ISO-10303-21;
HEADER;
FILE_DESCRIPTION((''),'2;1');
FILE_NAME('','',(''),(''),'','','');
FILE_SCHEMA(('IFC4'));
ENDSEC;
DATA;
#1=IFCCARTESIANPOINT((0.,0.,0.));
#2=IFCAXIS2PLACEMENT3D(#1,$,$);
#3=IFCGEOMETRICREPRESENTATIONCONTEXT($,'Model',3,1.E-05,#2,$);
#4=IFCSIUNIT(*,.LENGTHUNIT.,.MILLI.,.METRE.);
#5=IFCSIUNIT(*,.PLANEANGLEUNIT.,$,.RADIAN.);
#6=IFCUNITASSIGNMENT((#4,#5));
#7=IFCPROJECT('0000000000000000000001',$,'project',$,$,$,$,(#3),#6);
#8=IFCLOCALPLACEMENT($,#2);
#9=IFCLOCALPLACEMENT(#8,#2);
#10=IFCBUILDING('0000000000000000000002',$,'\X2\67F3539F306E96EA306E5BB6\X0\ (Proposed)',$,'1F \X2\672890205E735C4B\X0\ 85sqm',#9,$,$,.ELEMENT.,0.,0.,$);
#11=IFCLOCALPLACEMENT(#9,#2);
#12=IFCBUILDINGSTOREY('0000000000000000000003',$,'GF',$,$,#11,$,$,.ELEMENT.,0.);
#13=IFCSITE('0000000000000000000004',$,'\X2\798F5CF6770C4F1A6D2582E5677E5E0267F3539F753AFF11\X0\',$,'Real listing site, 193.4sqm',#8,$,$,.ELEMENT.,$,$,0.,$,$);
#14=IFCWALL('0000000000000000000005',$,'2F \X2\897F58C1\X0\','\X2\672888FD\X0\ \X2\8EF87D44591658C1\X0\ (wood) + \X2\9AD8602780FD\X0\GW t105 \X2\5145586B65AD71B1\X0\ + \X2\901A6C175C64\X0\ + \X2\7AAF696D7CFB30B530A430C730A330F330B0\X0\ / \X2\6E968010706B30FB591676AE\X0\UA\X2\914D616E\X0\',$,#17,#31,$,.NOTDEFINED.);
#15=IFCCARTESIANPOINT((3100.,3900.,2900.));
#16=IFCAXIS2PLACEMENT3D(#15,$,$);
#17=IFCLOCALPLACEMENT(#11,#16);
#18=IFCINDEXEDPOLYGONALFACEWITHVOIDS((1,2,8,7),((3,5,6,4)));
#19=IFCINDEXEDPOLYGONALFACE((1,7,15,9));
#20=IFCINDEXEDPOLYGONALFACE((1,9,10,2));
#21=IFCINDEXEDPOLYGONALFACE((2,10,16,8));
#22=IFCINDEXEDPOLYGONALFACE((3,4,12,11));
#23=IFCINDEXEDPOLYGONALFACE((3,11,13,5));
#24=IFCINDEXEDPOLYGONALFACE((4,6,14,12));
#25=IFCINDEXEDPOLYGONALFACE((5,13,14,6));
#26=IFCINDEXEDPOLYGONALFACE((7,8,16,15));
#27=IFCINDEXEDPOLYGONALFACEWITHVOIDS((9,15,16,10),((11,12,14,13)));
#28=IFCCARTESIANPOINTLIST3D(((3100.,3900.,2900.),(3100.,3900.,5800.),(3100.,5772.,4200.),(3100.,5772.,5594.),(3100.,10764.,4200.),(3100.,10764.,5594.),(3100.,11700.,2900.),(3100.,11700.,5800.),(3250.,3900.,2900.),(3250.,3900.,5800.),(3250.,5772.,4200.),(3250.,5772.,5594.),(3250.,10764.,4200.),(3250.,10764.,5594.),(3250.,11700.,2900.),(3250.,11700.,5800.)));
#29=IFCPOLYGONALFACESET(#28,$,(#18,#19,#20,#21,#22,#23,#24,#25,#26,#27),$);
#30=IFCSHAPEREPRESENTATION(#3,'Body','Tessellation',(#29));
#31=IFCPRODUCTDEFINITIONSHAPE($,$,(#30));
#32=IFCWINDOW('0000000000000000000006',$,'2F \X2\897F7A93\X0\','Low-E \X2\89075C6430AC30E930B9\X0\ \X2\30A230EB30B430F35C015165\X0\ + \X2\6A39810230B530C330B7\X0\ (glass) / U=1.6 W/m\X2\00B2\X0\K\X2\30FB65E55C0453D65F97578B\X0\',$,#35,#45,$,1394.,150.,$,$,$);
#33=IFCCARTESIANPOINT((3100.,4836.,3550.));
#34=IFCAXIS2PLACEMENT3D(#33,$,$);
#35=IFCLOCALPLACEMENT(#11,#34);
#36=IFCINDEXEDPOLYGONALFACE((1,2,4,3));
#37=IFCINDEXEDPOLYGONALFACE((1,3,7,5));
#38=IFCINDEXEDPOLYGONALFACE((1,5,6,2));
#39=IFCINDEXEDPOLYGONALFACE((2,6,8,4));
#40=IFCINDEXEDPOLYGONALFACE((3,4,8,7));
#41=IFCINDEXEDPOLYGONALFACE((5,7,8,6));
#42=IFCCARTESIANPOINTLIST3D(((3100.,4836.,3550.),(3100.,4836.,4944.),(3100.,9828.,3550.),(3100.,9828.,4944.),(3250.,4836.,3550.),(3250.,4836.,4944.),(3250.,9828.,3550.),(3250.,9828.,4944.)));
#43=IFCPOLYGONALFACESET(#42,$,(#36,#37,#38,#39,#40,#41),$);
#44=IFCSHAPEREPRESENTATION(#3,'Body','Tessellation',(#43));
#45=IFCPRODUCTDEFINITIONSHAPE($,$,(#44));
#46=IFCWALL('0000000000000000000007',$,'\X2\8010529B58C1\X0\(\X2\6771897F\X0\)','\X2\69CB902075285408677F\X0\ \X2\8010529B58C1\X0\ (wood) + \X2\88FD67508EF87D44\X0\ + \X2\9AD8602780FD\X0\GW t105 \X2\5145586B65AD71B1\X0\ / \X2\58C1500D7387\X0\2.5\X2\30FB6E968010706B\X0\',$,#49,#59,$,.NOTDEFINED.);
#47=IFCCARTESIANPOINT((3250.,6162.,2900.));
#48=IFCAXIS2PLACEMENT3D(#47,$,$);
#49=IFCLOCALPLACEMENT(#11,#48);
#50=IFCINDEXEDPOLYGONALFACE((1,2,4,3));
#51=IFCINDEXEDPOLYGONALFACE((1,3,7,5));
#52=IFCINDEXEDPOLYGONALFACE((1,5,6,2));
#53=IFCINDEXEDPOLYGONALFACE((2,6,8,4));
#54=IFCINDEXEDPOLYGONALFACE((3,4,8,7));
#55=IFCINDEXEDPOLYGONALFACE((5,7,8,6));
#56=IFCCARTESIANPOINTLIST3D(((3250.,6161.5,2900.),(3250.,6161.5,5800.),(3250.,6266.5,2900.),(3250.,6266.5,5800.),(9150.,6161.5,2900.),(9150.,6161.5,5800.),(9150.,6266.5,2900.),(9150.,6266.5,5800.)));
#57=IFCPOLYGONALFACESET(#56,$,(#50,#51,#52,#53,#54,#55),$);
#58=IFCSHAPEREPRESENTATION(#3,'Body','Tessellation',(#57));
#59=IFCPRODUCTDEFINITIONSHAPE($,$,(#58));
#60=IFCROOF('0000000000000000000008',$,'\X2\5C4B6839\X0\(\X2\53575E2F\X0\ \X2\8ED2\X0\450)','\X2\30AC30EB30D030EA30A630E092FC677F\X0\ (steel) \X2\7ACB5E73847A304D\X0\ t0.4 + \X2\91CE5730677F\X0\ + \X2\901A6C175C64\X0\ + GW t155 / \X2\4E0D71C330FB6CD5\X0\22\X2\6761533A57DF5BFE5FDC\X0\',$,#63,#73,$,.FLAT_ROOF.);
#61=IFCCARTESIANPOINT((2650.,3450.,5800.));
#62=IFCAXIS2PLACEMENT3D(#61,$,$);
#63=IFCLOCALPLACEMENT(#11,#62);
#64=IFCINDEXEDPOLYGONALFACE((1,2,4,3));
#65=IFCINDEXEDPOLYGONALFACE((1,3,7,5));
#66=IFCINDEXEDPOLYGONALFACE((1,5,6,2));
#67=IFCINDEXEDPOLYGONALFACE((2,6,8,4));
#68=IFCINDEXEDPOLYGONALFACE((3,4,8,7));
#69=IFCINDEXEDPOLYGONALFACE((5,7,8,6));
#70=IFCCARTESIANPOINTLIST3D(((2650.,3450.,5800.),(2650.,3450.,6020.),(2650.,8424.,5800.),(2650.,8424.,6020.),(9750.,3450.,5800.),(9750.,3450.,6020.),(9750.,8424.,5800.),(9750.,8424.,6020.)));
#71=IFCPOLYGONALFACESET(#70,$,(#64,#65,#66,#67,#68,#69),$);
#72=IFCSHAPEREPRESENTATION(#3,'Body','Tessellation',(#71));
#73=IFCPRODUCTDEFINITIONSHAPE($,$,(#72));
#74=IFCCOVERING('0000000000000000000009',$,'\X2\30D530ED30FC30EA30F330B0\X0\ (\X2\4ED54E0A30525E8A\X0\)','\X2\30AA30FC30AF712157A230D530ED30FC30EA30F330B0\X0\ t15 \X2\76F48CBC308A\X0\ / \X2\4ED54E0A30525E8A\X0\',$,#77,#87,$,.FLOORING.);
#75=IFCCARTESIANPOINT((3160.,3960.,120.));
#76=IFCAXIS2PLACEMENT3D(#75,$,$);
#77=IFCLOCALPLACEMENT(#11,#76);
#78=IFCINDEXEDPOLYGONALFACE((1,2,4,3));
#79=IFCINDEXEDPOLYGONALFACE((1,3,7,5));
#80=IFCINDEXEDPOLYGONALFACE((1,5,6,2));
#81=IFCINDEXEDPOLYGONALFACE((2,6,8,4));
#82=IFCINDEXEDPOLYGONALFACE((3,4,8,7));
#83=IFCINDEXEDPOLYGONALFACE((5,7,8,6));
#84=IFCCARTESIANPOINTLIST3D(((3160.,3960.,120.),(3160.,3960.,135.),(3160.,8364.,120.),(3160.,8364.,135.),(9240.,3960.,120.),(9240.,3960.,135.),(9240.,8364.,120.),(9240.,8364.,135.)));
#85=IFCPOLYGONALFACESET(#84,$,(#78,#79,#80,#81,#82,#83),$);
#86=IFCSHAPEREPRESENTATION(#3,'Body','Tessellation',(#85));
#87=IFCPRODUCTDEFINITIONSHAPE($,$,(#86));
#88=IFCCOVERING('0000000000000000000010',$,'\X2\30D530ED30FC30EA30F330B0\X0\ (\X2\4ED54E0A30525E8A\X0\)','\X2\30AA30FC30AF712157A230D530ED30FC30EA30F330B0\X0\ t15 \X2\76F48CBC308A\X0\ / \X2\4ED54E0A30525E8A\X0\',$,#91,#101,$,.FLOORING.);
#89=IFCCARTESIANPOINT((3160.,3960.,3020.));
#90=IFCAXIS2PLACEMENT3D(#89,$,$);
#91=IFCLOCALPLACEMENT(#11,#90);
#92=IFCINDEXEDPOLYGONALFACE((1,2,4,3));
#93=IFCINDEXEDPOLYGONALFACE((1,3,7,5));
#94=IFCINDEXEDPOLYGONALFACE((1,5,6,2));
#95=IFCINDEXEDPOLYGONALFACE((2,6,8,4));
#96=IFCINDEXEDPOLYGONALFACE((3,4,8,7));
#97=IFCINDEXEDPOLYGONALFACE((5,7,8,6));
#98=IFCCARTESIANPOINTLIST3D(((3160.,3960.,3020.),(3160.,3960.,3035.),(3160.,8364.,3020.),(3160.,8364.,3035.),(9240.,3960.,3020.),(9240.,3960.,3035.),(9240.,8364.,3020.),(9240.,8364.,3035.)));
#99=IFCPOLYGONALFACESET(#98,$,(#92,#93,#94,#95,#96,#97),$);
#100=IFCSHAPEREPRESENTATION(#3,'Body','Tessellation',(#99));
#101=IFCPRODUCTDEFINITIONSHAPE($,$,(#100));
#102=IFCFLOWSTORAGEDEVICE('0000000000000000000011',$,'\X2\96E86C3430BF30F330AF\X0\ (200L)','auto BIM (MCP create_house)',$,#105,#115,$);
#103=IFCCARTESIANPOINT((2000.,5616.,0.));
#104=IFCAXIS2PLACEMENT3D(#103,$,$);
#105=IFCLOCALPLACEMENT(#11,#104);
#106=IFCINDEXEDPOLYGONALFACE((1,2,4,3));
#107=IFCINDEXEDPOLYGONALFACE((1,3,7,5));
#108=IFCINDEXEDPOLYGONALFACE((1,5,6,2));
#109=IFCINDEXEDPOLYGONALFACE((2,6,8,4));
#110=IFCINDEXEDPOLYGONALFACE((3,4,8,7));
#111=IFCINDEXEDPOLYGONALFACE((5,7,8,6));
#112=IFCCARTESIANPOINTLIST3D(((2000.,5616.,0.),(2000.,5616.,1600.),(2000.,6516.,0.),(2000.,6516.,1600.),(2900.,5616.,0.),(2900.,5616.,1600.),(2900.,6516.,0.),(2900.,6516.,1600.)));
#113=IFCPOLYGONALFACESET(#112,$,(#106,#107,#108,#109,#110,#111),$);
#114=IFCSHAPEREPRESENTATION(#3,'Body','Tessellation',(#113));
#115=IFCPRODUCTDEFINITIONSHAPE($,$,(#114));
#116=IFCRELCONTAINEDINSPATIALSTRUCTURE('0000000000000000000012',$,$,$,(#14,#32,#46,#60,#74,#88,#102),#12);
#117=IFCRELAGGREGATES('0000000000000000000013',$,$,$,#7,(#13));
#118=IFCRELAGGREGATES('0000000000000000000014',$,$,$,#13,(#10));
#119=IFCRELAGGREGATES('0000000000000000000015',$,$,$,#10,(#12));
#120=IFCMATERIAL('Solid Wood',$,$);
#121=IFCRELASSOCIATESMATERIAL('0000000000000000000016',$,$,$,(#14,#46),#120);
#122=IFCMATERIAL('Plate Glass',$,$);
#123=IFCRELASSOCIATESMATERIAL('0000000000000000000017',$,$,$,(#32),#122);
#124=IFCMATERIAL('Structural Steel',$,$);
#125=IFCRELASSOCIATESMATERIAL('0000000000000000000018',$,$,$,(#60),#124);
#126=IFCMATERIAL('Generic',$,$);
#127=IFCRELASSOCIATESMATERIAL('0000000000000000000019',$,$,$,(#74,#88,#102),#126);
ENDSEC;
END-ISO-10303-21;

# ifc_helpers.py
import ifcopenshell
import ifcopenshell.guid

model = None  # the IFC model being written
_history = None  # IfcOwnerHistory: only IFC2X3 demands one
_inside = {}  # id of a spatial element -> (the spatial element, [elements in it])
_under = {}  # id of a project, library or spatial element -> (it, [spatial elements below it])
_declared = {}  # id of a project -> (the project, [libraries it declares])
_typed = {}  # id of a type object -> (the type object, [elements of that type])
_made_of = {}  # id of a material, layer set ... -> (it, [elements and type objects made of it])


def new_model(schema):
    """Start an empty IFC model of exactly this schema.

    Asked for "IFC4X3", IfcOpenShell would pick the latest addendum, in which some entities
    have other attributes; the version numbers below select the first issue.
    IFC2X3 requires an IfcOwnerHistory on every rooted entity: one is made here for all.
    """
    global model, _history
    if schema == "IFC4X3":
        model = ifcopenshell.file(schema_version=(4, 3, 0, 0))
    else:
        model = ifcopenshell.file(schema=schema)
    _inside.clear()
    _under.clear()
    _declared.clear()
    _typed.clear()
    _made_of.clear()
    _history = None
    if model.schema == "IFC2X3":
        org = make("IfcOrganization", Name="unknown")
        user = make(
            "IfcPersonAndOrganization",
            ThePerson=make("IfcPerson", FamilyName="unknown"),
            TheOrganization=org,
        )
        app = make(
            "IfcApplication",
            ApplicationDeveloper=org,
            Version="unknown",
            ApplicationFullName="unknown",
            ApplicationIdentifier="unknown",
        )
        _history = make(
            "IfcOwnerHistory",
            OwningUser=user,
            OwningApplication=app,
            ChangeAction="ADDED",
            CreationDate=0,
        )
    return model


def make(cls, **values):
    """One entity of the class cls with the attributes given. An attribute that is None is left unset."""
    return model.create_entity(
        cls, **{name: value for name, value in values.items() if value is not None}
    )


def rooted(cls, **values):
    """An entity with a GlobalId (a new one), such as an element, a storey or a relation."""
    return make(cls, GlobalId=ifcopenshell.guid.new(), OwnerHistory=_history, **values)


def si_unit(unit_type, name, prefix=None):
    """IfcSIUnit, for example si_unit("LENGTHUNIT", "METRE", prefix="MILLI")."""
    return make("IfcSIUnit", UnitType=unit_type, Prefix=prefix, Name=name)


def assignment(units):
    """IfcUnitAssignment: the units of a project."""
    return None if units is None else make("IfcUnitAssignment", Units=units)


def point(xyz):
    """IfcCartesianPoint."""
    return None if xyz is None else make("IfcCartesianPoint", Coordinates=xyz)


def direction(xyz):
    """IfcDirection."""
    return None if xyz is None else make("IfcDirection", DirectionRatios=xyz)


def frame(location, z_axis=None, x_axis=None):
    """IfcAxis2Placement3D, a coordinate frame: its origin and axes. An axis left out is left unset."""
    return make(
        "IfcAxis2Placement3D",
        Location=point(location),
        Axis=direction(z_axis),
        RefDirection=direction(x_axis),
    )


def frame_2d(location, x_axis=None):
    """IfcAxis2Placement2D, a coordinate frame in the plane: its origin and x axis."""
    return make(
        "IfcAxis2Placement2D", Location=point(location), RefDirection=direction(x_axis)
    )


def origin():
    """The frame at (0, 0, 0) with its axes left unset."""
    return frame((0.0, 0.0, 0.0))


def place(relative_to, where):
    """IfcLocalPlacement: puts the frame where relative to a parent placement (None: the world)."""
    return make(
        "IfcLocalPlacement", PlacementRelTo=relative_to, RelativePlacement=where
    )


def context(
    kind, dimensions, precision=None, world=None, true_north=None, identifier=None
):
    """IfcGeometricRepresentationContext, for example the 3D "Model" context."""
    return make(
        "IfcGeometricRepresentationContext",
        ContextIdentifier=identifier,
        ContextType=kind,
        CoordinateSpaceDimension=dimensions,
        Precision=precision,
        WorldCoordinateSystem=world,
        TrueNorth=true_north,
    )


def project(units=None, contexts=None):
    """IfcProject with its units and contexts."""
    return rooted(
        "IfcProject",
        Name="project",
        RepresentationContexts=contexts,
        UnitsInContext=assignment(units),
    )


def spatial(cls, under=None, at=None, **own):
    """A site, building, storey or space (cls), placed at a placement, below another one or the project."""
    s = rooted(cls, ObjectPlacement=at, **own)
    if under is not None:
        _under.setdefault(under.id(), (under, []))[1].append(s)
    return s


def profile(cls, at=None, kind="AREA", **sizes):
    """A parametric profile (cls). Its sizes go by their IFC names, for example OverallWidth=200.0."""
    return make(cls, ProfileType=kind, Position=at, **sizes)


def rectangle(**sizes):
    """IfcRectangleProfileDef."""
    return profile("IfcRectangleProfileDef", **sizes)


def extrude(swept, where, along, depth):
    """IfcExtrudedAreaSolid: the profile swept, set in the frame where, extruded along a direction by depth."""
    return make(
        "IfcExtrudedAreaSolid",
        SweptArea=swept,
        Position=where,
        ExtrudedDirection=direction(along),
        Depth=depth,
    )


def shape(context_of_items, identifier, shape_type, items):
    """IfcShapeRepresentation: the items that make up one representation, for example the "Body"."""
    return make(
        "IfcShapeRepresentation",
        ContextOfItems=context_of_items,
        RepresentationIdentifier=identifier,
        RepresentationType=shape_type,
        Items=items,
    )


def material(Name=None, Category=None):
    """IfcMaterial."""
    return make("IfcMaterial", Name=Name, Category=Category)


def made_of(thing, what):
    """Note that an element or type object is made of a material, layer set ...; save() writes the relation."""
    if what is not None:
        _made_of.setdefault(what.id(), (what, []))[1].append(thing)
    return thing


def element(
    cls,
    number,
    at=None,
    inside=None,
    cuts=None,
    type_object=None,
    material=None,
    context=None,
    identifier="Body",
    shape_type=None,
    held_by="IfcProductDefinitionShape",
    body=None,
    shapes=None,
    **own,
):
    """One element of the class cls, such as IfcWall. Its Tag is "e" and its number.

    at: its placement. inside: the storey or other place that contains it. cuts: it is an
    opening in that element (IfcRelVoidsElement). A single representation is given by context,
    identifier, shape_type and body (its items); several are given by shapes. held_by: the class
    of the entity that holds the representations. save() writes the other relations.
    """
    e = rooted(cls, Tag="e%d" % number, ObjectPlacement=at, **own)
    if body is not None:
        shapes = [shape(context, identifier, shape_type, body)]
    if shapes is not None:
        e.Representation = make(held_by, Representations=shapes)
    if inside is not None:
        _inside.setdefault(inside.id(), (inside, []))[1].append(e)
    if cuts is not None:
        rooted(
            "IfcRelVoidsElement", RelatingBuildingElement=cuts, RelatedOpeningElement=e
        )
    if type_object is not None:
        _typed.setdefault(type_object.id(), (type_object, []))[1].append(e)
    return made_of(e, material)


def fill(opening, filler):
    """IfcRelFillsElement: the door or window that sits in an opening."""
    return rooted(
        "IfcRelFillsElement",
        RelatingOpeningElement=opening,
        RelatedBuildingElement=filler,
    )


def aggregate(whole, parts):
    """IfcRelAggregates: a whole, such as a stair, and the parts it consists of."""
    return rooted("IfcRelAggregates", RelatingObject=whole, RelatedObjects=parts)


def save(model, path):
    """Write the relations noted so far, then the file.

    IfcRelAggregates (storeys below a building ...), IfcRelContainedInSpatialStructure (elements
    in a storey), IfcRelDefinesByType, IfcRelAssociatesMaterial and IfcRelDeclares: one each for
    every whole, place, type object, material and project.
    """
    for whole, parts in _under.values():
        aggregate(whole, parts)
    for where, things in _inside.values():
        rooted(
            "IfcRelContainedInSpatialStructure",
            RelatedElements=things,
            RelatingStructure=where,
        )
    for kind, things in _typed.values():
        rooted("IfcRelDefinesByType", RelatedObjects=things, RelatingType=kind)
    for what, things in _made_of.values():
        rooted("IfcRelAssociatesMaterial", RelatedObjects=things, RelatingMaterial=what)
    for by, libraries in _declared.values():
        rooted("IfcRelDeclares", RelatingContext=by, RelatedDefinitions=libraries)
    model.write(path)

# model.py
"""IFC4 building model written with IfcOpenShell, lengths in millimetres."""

from ifc_helpers import new_model, si_unit, frame, frame_2d, origin, place, context, project, spatial, rectangle, extrude, material, element, fill, save


model = new_model("IFC4")

# Units and contexts
model_context = context("Model", 3, precision=1e-05, world=origin())
ifc_project = project(units=[si_unit("LENGTHUNIT", "METRE", prefix="MILLI"), si_unit("PLANEANGLEUNIT", "RADIAN")], contexts=[model_context])

# Site, building, storey
site_placement = place(None, origin())
site = spatial("IfcSite", under=ifc_project, at=site_placement, Name="福島県会津若松市柳原町１", ObjectType="Real listing site, 193.4sqm", CompositionType="ELEMENT", RefElevation=0.0)
building_placement = place(site_placement, origin())
building = spatial("IfcBuilding", under=site, at=building_placement, Name="柳原の雪の家 (Proposed)", ObjectType="1F 木造平屋 85sqm", CompositionType="ELEMENT", ElevationOfRefHeight=0.0, ElevationOfTerrain=0.0)
storey_placement = place(building_placement, origin())
storey = spatial("IfcBuildingStorey", under=building, at=storey_placement, Name="GF", CompositionType="ELEMENT", Elevation=0.0)

# Shared definitions
ifc_material_1 = material(Name="Solid Wood")
ifc_material_2 = material(Name="Generic")

# Shared definitions
ifc_material_3 = material(Name="Plate Glass")

# Wall, opening, window
wall_1_placement = place(storey_placement, frame((3100.0, 3900.0, 2900.0)))
wall_1 = element("IfcWall", 1, at=wall_1_placement, inside=storey, material=ifc_material_1, Name="2F 西壁", Description="木製 軸組外壁 (wood) + 高性能GW t105 充填断熱 + 通気層 + 窯業系サイディング / 準耐火・外皮UA配慮", PredefinedType="NOTDEFINED", context=model_context, shape_type="SweptSolid", body=[
    extrude(rectangle(XDim=150.0, YDim=7800.0, at=frame_2d((75.0, 3900.0))), frame((3100.0, 3900.0, 2900.0)), (0.0, 0.0, 1.0), 2900.0),
])
opening_1_placement = place(storey_placement, frame((3100.0, 4836.0, 3550.0)))
opening_1 = element("IfcOpeningElement", 2, at=opening_1_placement, cuts=wall_1, PredefinedType="NOTDEFINED", context=model_context, shape_type="SweptSolid", body=[
    extrude(rectangle(XDim=150.0, YDim=4992.0, at=frame_2d((75.0, 2496.0))), frame((3100.0, 4836.0, 3550.0)), (0.0, 0.0, 1.0), 1394.0),
])
window_1_placement = place(storey_placement, frame((3100.0, 4836.0, 3550.0)))
window_1 = element("IfcWindow", 3, at=window_1_placement, inside=storey, material=ifc_material_3, Name="2F 西窓", Description="Low-E 複層ガラス アルゴン封入 + 樹脂サッシ (glass) / U=1.6 W/m²K・日射取得型", OverallHeight=1394.0, OverallWidth=150.0, context=model_context, shape_type="SweptSolid", body=[
    extrude(rectangle(XDim=150.0, YDim=4992.0, at=frame_2d((75.0, 2496.0))), frame((3100.0, 4836.0, 3550.0)), (0.0, 0.0, 1.0), 1394.0),
])
fill(opening_1, window_1)

# Wall
wall_2_placement = place(storey_placement, frame((3250.0, 6162.0, 2900.0)))
element("IfcWall", 4, at=wall_2_placement, inside=storey, material=ifc_material_1, Name="耐力壁(東西)", Description="構造用合板 耐力壁 (wood) + 製材軸組 + 高性能GW t105 充填断熱 / 壁倍率2.5・準耐火", PredefinedType="NOTDEFINED", context=model_context, shape_type="SweptSolid", body=[
    extrude(rectangle(XDim=5900.0, YDim=105.0, at=frame_2d((2950.0, 52.0))), frame((3250.0, 6162.0, 2900.0)), (0.0, 0.0, 1.0), 2900.0),
])

# Roof
ifc_material_4 = material(Name="Structural Steel")
for number, where, name in (
    (5, (2650.0, 3450.0, 5800.0), "屋根(南帯 軒450)"),
):
    element("IfcRoof", number, at=place(storey_placement, frame(where)), inside=storey, material=ifc_material_4, Name=name, Description="ガルバリウム鋼板 (steel) 立平葺き t0.4 + 野地板 + 通気層 + GW t155 / 不燃・法22条区域対応", PredefinedType="FLAT_ROOF", context=model_context, shape_type="SweptSolid", body=[
        extrude(rectangle(XDim=7100.0, YDim=4974.0, at=frame_2d((3550.0, 2487.0))), frame((2650.0, 3450.0, 5800.0)), (0.0, 0.0, 1.0), 220.0),
    ])

# Coverings
covering_1_placement = place(storey_placement, frame((3160.0, 3960.0, 120.0)))
element("IfcCovering", 6, at=covering_1_placement, inside=storey, material=ifc_material_2, Name="フローリング (仕上げ床)", Description="オーク無垢フローリング t15 直貼り / 仕上げ床", PredefinedType="FLOORING", context=model_context, shape_type="SweptSolid", body=[
    extrude(rectangle(XDim=6080.0, YDim=4404.0, at=frame_2d((3040.0, 2202.0))), frame((3160.0, 3960.0, 120.0)), (0.0, 0.0, 1.0), 15.0),
])
covering_2_placement = place(storey_placement, frame((3160.0, 3960.0, 3020.0)))
element("IfcCovering", 7, at=covering_2_placement, inside=storey, material=ifc_material_2, Name="フローリング (仕上げ床)", Description="オーク無垢フローリング t15 直貼り / 仕上げ床", PredefinedType="FLOORING", context=model_context, shape_type="SweptSolid", body=[
    extrude(rectangle(XDim=6080.0, YDim=4404.0, at=frame_2d((3040.0, 2202.0))), frame((3160.0, 3960.0, 3020.0)), (0.0, 0.0, 1.0), 15.0),
])

# Flow storage device
flow_storage_device_placement = place(storey_placement, frame((2000.0, 5616.0, 0.0)))
element("IfcFlowStorageDevice", 8, at=flow_storage_device_placement, inside=storey, material=ifc_material_2, Name="雨水タンク (200L)", Description="auto BIM (MCP create_house)", context=model_context, shape_type="SweptSolid", body=[
    extrude(rectangle(XDim=900.0, YDim=900.0, at=frame_2d((450.0, 450.0))), frame((2000.0, 5616.0, 0.0)), (0.0, 0.0, 1.0), 1600.0),
])

save(model, "model.ifc")
